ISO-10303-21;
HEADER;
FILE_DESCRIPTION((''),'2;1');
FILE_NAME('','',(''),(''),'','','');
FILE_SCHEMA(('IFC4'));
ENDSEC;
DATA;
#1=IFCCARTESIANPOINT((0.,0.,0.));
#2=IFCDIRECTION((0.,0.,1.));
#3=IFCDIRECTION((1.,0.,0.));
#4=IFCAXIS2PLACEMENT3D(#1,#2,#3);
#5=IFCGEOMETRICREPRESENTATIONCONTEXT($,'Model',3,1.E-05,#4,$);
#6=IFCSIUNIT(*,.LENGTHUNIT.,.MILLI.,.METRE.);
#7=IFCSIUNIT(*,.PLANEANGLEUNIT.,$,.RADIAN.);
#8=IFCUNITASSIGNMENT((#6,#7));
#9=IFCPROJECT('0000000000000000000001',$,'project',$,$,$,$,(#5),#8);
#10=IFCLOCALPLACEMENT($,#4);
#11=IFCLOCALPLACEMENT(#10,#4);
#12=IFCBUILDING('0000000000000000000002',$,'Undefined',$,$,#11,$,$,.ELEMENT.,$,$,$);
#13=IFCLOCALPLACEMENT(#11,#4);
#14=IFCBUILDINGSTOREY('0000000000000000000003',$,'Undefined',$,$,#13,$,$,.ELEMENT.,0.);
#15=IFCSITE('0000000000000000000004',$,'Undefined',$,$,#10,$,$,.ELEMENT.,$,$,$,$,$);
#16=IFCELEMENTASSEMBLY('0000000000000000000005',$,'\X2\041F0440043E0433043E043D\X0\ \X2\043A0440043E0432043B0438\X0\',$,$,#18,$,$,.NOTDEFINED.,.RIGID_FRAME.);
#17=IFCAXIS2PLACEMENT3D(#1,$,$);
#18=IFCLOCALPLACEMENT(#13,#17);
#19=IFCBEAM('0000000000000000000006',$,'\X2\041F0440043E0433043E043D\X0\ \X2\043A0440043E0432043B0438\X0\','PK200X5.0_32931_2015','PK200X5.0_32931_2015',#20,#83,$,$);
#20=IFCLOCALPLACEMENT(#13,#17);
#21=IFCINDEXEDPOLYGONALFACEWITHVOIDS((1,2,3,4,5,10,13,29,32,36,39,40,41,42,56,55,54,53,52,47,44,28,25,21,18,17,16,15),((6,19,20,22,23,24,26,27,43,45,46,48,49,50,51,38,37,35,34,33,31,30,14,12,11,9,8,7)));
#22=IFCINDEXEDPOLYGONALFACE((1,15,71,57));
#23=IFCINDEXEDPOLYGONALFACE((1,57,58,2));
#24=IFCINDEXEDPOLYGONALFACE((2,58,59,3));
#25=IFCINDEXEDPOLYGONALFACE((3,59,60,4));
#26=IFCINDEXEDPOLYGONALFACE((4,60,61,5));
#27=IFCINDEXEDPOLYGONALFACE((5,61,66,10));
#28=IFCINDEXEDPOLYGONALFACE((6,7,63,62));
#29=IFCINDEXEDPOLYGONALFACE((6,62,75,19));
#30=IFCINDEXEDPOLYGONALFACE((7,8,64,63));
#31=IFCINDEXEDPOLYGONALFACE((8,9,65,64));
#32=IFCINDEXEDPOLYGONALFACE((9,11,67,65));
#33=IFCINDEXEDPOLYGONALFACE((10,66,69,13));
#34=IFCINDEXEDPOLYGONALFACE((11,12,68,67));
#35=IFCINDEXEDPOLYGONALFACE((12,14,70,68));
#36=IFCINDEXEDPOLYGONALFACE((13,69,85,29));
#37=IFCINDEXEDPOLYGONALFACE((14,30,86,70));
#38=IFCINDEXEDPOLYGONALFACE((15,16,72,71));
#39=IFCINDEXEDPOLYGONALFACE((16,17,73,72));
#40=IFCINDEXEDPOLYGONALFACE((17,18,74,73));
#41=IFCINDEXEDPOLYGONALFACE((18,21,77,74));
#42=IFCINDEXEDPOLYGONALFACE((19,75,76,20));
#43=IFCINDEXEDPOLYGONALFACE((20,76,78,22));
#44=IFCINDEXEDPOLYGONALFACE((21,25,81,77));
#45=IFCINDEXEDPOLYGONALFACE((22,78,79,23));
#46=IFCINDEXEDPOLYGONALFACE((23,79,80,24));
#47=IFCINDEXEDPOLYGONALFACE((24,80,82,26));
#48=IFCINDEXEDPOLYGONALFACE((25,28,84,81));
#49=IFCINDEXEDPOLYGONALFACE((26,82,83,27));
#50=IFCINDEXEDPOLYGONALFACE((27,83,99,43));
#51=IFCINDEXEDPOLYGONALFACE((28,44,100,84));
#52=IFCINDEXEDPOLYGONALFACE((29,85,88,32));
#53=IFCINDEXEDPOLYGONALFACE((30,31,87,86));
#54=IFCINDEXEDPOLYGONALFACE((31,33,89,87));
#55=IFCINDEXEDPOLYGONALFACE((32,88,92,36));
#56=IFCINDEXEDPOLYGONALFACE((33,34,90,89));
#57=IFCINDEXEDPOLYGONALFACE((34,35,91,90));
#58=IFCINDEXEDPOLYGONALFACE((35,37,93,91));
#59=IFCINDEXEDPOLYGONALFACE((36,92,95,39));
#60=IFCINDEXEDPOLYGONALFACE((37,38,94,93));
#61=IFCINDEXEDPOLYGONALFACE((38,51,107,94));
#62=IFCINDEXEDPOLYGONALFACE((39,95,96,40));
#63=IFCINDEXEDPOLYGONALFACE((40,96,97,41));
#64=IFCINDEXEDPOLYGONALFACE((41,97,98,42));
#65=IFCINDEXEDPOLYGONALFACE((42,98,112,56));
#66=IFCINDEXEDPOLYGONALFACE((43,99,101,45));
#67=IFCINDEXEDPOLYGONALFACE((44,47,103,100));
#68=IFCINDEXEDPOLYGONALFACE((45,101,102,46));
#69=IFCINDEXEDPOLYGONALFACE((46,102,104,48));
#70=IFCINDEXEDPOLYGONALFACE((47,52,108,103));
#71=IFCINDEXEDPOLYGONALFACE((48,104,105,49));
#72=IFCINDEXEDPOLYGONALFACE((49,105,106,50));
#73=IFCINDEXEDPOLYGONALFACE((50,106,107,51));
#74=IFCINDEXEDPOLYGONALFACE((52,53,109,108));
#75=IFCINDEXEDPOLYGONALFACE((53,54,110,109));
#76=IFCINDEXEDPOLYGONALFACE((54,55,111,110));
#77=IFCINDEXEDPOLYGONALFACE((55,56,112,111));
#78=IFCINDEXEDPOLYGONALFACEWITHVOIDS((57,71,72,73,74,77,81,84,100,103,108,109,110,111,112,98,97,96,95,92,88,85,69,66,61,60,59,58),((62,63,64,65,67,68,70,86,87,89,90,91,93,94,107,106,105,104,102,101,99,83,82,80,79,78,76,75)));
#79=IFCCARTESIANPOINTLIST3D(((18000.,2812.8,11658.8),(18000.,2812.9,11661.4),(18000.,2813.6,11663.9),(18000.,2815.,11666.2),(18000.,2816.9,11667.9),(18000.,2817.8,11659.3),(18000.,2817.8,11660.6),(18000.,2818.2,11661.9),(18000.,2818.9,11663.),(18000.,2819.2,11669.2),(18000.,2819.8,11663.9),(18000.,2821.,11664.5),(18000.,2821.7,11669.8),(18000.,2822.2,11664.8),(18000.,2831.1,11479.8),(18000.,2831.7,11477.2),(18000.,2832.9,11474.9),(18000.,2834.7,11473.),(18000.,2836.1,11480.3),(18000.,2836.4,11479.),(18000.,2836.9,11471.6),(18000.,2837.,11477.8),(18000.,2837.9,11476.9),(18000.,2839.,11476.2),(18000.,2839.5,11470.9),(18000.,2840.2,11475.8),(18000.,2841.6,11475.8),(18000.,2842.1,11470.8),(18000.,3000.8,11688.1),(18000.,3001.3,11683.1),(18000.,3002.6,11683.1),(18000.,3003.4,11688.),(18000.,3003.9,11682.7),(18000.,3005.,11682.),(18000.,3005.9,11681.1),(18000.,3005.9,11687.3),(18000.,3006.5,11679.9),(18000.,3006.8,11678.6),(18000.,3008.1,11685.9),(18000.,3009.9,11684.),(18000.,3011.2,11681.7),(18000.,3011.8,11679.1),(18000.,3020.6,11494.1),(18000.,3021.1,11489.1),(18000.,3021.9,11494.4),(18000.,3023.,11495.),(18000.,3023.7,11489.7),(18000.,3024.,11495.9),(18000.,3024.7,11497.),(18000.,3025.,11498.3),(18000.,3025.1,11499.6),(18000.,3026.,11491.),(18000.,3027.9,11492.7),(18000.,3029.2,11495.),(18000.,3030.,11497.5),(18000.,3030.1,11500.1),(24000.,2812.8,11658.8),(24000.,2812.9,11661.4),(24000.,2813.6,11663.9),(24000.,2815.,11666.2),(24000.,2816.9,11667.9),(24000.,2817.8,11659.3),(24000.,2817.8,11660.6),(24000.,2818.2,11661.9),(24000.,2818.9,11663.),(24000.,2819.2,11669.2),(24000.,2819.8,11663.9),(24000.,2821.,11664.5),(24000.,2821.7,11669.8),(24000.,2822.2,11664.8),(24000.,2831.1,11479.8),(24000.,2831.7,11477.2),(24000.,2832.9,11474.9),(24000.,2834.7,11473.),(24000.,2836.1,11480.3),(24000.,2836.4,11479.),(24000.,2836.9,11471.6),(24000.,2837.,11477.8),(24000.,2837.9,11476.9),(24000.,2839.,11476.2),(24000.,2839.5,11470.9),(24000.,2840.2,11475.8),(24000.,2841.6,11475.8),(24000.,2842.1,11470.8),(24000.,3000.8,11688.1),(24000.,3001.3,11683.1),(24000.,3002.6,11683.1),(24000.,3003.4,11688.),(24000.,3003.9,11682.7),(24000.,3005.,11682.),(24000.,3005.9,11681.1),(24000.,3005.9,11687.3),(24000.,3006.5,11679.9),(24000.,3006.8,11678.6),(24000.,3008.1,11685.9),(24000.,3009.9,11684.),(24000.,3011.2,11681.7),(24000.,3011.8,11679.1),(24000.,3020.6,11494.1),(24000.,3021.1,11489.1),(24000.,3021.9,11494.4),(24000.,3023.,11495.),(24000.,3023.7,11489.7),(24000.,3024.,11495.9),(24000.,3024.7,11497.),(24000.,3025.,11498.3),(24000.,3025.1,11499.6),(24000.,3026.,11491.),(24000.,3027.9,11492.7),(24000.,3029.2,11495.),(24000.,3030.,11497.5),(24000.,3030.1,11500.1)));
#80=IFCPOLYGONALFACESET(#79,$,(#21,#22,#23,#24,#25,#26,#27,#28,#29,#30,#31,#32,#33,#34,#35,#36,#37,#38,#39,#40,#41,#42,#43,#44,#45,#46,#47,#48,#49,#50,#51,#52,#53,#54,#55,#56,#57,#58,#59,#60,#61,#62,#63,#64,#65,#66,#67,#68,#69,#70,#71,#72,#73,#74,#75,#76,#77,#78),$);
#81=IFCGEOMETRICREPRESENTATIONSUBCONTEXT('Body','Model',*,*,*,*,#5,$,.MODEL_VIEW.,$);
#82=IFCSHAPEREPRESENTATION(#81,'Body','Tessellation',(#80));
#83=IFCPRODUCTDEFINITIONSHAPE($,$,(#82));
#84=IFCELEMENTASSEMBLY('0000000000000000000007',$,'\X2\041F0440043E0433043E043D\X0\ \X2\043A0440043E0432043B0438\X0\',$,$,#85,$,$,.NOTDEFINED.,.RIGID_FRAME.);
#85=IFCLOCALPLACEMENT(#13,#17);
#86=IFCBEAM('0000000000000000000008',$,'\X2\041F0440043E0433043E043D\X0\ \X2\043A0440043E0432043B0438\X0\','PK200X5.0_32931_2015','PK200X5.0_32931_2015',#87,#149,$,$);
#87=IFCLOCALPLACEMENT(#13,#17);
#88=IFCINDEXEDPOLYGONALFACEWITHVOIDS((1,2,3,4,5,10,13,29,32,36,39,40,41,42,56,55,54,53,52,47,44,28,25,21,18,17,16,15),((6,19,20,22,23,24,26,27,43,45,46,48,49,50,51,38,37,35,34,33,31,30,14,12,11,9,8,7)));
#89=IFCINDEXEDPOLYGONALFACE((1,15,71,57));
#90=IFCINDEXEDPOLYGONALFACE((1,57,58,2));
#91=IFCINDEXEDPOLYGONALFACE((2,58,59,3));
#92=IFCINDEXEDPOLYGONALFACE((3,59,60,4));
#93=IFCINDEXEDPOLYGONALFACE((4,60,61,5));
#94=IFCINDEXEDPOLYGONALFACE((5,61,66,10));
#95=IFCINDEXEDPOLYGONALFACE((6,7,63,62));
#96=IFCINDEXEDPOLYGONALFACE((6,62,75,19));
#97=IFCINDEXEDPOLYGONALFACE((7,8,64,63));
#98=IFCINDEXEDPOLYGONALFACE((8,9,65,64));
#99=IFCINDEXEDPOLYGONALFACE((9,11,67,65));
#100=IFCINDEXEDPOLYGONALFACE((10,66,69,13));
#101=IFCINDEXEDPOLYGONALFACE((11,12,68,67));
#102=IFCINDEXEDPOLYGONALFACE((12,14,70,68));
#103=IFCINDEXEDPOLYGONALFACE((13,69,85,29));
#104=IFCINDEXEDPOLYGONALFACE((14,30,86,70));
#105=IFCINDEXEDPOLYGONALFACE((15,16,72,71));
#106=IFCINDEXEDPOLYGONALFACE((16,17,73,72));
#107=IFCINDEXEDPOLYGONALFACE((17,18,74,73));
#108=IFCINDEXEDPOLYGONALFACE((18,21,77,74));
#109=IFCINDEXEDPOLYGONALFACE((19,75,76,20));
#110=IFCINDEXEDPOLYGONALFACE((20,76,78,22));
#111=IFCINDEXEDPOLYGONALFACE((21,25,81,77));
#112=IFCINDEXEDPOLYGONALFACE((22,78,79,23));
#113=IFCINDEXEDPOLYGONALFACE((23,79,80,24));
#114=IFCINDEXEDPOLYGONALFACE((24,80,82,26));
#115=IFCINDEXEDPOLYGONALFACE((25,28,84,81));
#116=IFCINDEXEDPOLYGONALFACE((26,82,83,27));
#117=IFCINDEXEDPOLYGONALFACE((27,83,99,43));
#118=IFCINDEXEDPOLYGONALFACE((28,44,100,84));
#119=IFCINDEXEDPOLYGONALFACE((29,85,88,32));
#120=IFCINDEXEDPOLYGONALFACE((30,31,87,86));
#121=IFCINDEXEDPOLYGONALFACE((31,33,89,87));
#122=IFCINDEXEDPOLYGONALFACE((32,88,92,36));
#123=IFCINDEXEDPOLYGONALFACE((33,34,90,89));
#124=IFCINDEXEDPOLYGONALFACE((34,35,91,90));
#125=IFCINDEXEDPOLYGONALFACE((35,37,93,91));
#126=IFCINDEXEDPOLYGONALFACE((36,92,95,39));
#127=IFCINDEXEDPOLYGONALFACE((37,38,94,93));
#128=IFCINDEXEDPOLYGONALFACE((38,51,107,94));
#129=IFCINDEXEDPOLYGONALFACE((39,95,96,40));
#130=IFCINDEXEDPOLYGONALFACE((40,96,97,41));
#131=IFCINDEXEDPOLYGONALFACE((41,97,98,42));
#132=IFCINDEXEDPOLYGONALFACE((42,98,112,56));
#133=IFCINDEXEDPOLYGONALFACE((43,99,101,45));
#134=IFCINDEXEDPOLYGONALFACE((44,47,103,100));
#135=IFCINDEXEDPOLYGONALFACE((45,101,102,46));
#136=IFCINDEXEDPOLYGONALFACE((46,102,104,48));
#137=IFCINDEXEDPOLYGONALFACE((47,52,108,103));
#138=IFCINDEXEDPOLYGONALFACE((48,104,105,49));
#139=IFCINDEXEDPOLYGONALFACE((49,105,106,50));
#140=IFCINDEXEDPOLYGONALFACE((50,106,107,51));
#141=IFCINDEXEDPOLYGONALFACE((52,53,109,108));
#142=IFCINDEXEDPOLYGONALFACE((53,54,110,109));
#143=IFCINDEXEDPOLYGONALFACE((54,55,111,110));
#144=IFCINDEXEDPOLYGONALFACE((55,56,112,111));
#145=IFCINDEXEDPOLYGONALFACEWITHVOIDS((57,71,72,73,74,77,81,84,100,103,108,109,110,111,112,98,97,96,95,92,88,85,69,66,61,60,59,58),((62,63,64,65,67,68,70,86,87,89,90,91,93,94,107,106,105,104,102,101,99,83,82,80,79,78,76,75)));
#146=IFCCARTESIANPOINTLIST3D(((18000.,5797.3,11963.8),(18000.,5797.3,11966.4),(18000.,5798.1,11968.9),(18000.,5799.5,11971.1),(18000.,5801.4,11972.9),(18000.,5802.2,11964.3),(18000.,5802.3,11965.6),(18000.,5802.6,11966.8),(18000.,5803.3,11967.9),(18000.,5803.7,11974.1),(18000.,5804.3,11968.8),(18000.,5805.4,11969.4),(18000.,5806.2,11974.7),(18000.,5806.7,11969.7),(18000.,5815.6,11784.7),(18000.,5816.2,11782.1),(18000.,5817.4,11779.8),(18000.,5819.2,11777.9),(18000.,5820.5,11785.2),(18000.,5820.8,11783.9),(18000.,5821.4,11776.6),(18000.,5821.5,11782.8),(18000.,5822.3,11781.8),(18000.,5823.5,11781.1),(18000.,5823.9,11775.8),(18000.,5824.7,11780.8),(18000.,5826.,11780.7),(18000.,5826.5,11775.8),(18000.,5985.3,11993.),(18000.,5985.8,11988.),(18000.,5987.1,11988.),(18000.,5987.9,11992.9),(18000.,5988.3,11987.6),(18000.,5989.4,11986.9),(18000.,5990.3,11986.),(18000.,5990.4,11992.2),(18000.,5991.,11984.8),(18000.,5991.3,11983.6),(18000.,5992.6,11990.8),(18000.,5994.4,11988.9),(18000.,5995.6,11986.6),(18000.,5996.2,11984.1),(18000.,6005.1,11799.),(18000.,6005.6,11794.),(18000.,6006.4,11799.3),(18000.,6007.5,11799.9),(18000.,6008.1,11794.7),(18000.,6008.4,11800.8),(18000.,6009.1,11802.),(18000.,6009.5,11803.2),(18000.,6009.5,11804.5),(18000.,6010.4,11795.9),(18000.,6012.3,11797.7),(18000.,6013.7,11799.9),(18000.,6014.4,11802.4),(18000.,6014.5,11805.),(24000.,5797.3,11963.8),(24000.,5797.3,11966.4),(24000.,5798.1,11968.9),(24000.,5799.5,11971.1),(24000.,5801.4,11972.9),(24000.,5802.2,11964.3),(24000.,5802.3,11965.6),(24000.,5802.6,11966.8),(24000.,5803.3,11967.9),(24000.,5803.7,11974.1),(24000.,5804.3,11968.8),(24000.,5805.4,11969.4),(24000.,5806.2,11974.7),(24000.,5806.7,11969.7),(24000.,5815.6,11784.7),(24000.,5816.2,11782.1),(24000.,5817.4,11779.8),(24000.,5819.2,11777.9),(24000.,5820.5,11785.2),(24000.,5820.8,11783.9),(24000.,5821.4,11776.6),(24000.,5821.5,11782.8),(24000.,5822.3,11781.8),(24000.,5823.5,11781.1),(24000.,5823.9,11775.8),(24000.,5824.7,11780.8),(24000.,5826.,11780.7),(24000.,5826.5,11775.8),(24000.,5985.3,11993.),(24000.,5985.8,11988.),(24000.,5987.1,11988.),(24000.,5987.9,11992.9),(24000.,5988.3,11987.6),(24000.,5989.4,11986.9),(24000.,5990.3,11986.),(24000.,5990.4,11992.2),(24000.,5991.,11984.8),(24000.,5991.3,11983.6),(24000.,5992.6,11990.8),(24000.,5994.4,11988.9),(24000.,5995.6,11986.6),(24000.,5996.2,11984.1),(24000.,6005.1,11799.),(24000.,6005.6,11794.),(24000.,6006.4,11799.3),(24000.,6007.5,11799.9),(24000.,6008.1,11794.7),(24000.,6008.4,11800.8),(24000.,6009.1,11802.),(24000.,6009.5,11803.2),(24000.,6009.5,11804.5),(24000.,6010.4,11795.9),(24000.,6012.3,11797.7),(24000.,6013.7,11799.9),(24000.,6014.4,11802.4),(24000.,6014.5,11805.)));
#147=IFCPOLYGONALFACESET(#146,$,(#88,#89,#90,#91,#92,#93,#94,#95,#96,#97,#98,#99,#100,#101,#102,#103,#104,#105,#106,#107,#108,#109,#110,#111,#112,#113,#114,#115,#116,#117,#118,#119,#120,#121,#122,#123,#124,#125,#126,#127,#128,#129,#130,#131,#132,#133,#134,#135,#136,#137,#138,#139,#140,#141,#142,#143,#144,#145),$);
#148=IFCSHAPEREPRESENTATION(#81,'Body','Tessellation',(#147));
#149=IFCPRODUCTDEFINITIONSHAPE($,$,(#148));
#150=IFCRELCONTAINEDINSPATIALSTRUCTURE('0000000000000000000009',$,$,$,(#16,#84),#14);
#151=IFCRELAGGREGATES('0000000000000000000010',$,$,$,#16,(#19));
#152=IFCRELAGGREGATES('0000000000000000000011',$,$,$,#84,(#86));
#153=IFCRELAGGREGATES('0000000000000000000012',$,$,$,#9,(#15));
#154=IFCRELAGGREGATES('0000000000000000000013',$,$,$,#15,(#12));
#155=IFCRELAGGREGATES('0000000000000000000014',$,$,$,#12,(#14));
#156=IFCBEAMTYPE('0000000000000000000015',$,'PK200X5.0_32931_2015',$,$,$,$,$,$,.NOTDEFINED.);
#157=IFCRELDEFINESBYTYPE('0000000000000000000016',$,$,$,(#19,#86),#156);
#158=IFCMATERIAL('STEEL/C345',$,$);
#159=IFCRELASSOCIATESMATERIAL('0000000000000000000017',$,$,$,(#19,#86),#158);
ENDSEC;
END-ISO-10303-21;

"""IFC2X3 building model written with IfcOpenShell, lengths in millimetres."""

from ifc_helpers import new_model, si_unit, frame, origin_with_axes, origin_2d_with_axis, place, context, subcontext, project, spatial, hollow_rectangle, extrude, material, type_object, element, aggregate, save


model = new_model("IFC2X3")

# Units and contexts
model_context = context("Model", 3, precision=1e-05, world=origin_with_axes())
body_context = subcontext(model_context, "Body", "Model", "MODEL_VIEW")
ifc_project = project(units=[si_unit("LENGTHUNIT", "METRE", prefix="MILLI"), si_unit("PLANEANGLEUNIT", "RADIAN")], contexts=[model_context])

# Site, building, storey
site_placement = place(None, origin_with_axes())
site = spatial("IfcSite", under=ifc_project, at=site_placement, Name="Undefined", CompositionType="ELEMENT")
building_placement = place(site_placement, origin_with_axes())
building = spatial("IfcBuilding", under=site, at=building_placement, Name="Undefined", CompositionType="ELEMENT")
storey_placement = place(building_placement, origin_with_axes())
storey = spatial("IfcBuildingStorey", under=building, at=storey_placement, Name="Undefined", CompositionType="ELEMENT", Elevation=0.0)

# Element assemblies, beams
assembly_1_placement = place(storey_placement, origin_with_axes())
assembly_1 = element("IfcElementAssembly", 1, at=assembly_1_placement, inside=storey, Name="Прогон кровли", AssemblyPlace="NOTDEFINED", PredefinedType="RIGID_FRAME")
ifc_material_1 = material(Name="STEEL/C345")
beam_type_1 = type_object("IfcBeamType", Name="PK200X5.0_32931_2015", PredefinedType="NOTDEFINED")
beam_1_placement = place(assembly_1_placement, frame((24000.0, 2921.4, 11579.4), z_axis=(0.0, -0.101645, 0.994821), x_axis=(-1.0, 0.0, 0.0)))
beam_1 = element("IfcBeam", 2, at=beam_1_placement, type_object=beam_type_1, material=ifc_material_1, Name="Прогон кровли", Description="PK200X5.0_32931_2015", ObjectType="PK200X5.0_32931_2015", context=body_context, shape_type="SweptSolid", body=[
    extrude(hollow_rectangle(XDim=200.0, YDim=200.0, WallThickness=5.0, InnerFilletRadius=5.0, OuterFilletRadius=10.0, at=origin_2d_with_axis()), frame((6000.0, 0.0, 0.0), z_axis=(-1.0, 0.0, 0.0), x_axis=(0.0, -1.0, 0.0)), (0.0, 0.0, 1.0), 6000.0),
])
aggregate(assembly_1, [beam_1])
assembly_2_placement = place(storey_placement, origin_with_axes())
assembly_2 = element("IfcElementAssembly", 3, at=assembly_2_placement, inside=storey, Name="Прогон кровли", AssemblyPlace="NOTDEFINED", PredefinedType="RIGID_FRAME")
beam_2_placement = place(assembly_2_placement, frame((24000.0, 5905.9, 11884.4), z_axis=(0.0, -0.101645, 0.994821), x_axis=(-1.0, 0.0, 0.0)))
beam_2 = element("IfcBeam", 4, at=beam_2_placement, type_object=beam_type_1, material=ifc_material_1, Name="Прогон кровли", Description="PK200X5.0_32931_2015", ObjectType="PK200X5.0_32931_2015", context=body_context, shape_type="SweptSolid", body=[
    extrude(hollow_rectangle(XDim=200.0, YDim=200.0, WallThickness=5.0, InnerFilletRadius=5.0, OuterFilletRadius=10.0, at=origin_2d_with_axis()), frame((6000.0, 0.0, 0.0), z_axis=(-1.0, 0.0, 0.0), x_axis=(0.0, -1.0, 0.0)), (0.0, 0.0, 1.0), 6000.0),
])
aggregate(assembly_2, [beam_2])

save(model, "model.ifc")
